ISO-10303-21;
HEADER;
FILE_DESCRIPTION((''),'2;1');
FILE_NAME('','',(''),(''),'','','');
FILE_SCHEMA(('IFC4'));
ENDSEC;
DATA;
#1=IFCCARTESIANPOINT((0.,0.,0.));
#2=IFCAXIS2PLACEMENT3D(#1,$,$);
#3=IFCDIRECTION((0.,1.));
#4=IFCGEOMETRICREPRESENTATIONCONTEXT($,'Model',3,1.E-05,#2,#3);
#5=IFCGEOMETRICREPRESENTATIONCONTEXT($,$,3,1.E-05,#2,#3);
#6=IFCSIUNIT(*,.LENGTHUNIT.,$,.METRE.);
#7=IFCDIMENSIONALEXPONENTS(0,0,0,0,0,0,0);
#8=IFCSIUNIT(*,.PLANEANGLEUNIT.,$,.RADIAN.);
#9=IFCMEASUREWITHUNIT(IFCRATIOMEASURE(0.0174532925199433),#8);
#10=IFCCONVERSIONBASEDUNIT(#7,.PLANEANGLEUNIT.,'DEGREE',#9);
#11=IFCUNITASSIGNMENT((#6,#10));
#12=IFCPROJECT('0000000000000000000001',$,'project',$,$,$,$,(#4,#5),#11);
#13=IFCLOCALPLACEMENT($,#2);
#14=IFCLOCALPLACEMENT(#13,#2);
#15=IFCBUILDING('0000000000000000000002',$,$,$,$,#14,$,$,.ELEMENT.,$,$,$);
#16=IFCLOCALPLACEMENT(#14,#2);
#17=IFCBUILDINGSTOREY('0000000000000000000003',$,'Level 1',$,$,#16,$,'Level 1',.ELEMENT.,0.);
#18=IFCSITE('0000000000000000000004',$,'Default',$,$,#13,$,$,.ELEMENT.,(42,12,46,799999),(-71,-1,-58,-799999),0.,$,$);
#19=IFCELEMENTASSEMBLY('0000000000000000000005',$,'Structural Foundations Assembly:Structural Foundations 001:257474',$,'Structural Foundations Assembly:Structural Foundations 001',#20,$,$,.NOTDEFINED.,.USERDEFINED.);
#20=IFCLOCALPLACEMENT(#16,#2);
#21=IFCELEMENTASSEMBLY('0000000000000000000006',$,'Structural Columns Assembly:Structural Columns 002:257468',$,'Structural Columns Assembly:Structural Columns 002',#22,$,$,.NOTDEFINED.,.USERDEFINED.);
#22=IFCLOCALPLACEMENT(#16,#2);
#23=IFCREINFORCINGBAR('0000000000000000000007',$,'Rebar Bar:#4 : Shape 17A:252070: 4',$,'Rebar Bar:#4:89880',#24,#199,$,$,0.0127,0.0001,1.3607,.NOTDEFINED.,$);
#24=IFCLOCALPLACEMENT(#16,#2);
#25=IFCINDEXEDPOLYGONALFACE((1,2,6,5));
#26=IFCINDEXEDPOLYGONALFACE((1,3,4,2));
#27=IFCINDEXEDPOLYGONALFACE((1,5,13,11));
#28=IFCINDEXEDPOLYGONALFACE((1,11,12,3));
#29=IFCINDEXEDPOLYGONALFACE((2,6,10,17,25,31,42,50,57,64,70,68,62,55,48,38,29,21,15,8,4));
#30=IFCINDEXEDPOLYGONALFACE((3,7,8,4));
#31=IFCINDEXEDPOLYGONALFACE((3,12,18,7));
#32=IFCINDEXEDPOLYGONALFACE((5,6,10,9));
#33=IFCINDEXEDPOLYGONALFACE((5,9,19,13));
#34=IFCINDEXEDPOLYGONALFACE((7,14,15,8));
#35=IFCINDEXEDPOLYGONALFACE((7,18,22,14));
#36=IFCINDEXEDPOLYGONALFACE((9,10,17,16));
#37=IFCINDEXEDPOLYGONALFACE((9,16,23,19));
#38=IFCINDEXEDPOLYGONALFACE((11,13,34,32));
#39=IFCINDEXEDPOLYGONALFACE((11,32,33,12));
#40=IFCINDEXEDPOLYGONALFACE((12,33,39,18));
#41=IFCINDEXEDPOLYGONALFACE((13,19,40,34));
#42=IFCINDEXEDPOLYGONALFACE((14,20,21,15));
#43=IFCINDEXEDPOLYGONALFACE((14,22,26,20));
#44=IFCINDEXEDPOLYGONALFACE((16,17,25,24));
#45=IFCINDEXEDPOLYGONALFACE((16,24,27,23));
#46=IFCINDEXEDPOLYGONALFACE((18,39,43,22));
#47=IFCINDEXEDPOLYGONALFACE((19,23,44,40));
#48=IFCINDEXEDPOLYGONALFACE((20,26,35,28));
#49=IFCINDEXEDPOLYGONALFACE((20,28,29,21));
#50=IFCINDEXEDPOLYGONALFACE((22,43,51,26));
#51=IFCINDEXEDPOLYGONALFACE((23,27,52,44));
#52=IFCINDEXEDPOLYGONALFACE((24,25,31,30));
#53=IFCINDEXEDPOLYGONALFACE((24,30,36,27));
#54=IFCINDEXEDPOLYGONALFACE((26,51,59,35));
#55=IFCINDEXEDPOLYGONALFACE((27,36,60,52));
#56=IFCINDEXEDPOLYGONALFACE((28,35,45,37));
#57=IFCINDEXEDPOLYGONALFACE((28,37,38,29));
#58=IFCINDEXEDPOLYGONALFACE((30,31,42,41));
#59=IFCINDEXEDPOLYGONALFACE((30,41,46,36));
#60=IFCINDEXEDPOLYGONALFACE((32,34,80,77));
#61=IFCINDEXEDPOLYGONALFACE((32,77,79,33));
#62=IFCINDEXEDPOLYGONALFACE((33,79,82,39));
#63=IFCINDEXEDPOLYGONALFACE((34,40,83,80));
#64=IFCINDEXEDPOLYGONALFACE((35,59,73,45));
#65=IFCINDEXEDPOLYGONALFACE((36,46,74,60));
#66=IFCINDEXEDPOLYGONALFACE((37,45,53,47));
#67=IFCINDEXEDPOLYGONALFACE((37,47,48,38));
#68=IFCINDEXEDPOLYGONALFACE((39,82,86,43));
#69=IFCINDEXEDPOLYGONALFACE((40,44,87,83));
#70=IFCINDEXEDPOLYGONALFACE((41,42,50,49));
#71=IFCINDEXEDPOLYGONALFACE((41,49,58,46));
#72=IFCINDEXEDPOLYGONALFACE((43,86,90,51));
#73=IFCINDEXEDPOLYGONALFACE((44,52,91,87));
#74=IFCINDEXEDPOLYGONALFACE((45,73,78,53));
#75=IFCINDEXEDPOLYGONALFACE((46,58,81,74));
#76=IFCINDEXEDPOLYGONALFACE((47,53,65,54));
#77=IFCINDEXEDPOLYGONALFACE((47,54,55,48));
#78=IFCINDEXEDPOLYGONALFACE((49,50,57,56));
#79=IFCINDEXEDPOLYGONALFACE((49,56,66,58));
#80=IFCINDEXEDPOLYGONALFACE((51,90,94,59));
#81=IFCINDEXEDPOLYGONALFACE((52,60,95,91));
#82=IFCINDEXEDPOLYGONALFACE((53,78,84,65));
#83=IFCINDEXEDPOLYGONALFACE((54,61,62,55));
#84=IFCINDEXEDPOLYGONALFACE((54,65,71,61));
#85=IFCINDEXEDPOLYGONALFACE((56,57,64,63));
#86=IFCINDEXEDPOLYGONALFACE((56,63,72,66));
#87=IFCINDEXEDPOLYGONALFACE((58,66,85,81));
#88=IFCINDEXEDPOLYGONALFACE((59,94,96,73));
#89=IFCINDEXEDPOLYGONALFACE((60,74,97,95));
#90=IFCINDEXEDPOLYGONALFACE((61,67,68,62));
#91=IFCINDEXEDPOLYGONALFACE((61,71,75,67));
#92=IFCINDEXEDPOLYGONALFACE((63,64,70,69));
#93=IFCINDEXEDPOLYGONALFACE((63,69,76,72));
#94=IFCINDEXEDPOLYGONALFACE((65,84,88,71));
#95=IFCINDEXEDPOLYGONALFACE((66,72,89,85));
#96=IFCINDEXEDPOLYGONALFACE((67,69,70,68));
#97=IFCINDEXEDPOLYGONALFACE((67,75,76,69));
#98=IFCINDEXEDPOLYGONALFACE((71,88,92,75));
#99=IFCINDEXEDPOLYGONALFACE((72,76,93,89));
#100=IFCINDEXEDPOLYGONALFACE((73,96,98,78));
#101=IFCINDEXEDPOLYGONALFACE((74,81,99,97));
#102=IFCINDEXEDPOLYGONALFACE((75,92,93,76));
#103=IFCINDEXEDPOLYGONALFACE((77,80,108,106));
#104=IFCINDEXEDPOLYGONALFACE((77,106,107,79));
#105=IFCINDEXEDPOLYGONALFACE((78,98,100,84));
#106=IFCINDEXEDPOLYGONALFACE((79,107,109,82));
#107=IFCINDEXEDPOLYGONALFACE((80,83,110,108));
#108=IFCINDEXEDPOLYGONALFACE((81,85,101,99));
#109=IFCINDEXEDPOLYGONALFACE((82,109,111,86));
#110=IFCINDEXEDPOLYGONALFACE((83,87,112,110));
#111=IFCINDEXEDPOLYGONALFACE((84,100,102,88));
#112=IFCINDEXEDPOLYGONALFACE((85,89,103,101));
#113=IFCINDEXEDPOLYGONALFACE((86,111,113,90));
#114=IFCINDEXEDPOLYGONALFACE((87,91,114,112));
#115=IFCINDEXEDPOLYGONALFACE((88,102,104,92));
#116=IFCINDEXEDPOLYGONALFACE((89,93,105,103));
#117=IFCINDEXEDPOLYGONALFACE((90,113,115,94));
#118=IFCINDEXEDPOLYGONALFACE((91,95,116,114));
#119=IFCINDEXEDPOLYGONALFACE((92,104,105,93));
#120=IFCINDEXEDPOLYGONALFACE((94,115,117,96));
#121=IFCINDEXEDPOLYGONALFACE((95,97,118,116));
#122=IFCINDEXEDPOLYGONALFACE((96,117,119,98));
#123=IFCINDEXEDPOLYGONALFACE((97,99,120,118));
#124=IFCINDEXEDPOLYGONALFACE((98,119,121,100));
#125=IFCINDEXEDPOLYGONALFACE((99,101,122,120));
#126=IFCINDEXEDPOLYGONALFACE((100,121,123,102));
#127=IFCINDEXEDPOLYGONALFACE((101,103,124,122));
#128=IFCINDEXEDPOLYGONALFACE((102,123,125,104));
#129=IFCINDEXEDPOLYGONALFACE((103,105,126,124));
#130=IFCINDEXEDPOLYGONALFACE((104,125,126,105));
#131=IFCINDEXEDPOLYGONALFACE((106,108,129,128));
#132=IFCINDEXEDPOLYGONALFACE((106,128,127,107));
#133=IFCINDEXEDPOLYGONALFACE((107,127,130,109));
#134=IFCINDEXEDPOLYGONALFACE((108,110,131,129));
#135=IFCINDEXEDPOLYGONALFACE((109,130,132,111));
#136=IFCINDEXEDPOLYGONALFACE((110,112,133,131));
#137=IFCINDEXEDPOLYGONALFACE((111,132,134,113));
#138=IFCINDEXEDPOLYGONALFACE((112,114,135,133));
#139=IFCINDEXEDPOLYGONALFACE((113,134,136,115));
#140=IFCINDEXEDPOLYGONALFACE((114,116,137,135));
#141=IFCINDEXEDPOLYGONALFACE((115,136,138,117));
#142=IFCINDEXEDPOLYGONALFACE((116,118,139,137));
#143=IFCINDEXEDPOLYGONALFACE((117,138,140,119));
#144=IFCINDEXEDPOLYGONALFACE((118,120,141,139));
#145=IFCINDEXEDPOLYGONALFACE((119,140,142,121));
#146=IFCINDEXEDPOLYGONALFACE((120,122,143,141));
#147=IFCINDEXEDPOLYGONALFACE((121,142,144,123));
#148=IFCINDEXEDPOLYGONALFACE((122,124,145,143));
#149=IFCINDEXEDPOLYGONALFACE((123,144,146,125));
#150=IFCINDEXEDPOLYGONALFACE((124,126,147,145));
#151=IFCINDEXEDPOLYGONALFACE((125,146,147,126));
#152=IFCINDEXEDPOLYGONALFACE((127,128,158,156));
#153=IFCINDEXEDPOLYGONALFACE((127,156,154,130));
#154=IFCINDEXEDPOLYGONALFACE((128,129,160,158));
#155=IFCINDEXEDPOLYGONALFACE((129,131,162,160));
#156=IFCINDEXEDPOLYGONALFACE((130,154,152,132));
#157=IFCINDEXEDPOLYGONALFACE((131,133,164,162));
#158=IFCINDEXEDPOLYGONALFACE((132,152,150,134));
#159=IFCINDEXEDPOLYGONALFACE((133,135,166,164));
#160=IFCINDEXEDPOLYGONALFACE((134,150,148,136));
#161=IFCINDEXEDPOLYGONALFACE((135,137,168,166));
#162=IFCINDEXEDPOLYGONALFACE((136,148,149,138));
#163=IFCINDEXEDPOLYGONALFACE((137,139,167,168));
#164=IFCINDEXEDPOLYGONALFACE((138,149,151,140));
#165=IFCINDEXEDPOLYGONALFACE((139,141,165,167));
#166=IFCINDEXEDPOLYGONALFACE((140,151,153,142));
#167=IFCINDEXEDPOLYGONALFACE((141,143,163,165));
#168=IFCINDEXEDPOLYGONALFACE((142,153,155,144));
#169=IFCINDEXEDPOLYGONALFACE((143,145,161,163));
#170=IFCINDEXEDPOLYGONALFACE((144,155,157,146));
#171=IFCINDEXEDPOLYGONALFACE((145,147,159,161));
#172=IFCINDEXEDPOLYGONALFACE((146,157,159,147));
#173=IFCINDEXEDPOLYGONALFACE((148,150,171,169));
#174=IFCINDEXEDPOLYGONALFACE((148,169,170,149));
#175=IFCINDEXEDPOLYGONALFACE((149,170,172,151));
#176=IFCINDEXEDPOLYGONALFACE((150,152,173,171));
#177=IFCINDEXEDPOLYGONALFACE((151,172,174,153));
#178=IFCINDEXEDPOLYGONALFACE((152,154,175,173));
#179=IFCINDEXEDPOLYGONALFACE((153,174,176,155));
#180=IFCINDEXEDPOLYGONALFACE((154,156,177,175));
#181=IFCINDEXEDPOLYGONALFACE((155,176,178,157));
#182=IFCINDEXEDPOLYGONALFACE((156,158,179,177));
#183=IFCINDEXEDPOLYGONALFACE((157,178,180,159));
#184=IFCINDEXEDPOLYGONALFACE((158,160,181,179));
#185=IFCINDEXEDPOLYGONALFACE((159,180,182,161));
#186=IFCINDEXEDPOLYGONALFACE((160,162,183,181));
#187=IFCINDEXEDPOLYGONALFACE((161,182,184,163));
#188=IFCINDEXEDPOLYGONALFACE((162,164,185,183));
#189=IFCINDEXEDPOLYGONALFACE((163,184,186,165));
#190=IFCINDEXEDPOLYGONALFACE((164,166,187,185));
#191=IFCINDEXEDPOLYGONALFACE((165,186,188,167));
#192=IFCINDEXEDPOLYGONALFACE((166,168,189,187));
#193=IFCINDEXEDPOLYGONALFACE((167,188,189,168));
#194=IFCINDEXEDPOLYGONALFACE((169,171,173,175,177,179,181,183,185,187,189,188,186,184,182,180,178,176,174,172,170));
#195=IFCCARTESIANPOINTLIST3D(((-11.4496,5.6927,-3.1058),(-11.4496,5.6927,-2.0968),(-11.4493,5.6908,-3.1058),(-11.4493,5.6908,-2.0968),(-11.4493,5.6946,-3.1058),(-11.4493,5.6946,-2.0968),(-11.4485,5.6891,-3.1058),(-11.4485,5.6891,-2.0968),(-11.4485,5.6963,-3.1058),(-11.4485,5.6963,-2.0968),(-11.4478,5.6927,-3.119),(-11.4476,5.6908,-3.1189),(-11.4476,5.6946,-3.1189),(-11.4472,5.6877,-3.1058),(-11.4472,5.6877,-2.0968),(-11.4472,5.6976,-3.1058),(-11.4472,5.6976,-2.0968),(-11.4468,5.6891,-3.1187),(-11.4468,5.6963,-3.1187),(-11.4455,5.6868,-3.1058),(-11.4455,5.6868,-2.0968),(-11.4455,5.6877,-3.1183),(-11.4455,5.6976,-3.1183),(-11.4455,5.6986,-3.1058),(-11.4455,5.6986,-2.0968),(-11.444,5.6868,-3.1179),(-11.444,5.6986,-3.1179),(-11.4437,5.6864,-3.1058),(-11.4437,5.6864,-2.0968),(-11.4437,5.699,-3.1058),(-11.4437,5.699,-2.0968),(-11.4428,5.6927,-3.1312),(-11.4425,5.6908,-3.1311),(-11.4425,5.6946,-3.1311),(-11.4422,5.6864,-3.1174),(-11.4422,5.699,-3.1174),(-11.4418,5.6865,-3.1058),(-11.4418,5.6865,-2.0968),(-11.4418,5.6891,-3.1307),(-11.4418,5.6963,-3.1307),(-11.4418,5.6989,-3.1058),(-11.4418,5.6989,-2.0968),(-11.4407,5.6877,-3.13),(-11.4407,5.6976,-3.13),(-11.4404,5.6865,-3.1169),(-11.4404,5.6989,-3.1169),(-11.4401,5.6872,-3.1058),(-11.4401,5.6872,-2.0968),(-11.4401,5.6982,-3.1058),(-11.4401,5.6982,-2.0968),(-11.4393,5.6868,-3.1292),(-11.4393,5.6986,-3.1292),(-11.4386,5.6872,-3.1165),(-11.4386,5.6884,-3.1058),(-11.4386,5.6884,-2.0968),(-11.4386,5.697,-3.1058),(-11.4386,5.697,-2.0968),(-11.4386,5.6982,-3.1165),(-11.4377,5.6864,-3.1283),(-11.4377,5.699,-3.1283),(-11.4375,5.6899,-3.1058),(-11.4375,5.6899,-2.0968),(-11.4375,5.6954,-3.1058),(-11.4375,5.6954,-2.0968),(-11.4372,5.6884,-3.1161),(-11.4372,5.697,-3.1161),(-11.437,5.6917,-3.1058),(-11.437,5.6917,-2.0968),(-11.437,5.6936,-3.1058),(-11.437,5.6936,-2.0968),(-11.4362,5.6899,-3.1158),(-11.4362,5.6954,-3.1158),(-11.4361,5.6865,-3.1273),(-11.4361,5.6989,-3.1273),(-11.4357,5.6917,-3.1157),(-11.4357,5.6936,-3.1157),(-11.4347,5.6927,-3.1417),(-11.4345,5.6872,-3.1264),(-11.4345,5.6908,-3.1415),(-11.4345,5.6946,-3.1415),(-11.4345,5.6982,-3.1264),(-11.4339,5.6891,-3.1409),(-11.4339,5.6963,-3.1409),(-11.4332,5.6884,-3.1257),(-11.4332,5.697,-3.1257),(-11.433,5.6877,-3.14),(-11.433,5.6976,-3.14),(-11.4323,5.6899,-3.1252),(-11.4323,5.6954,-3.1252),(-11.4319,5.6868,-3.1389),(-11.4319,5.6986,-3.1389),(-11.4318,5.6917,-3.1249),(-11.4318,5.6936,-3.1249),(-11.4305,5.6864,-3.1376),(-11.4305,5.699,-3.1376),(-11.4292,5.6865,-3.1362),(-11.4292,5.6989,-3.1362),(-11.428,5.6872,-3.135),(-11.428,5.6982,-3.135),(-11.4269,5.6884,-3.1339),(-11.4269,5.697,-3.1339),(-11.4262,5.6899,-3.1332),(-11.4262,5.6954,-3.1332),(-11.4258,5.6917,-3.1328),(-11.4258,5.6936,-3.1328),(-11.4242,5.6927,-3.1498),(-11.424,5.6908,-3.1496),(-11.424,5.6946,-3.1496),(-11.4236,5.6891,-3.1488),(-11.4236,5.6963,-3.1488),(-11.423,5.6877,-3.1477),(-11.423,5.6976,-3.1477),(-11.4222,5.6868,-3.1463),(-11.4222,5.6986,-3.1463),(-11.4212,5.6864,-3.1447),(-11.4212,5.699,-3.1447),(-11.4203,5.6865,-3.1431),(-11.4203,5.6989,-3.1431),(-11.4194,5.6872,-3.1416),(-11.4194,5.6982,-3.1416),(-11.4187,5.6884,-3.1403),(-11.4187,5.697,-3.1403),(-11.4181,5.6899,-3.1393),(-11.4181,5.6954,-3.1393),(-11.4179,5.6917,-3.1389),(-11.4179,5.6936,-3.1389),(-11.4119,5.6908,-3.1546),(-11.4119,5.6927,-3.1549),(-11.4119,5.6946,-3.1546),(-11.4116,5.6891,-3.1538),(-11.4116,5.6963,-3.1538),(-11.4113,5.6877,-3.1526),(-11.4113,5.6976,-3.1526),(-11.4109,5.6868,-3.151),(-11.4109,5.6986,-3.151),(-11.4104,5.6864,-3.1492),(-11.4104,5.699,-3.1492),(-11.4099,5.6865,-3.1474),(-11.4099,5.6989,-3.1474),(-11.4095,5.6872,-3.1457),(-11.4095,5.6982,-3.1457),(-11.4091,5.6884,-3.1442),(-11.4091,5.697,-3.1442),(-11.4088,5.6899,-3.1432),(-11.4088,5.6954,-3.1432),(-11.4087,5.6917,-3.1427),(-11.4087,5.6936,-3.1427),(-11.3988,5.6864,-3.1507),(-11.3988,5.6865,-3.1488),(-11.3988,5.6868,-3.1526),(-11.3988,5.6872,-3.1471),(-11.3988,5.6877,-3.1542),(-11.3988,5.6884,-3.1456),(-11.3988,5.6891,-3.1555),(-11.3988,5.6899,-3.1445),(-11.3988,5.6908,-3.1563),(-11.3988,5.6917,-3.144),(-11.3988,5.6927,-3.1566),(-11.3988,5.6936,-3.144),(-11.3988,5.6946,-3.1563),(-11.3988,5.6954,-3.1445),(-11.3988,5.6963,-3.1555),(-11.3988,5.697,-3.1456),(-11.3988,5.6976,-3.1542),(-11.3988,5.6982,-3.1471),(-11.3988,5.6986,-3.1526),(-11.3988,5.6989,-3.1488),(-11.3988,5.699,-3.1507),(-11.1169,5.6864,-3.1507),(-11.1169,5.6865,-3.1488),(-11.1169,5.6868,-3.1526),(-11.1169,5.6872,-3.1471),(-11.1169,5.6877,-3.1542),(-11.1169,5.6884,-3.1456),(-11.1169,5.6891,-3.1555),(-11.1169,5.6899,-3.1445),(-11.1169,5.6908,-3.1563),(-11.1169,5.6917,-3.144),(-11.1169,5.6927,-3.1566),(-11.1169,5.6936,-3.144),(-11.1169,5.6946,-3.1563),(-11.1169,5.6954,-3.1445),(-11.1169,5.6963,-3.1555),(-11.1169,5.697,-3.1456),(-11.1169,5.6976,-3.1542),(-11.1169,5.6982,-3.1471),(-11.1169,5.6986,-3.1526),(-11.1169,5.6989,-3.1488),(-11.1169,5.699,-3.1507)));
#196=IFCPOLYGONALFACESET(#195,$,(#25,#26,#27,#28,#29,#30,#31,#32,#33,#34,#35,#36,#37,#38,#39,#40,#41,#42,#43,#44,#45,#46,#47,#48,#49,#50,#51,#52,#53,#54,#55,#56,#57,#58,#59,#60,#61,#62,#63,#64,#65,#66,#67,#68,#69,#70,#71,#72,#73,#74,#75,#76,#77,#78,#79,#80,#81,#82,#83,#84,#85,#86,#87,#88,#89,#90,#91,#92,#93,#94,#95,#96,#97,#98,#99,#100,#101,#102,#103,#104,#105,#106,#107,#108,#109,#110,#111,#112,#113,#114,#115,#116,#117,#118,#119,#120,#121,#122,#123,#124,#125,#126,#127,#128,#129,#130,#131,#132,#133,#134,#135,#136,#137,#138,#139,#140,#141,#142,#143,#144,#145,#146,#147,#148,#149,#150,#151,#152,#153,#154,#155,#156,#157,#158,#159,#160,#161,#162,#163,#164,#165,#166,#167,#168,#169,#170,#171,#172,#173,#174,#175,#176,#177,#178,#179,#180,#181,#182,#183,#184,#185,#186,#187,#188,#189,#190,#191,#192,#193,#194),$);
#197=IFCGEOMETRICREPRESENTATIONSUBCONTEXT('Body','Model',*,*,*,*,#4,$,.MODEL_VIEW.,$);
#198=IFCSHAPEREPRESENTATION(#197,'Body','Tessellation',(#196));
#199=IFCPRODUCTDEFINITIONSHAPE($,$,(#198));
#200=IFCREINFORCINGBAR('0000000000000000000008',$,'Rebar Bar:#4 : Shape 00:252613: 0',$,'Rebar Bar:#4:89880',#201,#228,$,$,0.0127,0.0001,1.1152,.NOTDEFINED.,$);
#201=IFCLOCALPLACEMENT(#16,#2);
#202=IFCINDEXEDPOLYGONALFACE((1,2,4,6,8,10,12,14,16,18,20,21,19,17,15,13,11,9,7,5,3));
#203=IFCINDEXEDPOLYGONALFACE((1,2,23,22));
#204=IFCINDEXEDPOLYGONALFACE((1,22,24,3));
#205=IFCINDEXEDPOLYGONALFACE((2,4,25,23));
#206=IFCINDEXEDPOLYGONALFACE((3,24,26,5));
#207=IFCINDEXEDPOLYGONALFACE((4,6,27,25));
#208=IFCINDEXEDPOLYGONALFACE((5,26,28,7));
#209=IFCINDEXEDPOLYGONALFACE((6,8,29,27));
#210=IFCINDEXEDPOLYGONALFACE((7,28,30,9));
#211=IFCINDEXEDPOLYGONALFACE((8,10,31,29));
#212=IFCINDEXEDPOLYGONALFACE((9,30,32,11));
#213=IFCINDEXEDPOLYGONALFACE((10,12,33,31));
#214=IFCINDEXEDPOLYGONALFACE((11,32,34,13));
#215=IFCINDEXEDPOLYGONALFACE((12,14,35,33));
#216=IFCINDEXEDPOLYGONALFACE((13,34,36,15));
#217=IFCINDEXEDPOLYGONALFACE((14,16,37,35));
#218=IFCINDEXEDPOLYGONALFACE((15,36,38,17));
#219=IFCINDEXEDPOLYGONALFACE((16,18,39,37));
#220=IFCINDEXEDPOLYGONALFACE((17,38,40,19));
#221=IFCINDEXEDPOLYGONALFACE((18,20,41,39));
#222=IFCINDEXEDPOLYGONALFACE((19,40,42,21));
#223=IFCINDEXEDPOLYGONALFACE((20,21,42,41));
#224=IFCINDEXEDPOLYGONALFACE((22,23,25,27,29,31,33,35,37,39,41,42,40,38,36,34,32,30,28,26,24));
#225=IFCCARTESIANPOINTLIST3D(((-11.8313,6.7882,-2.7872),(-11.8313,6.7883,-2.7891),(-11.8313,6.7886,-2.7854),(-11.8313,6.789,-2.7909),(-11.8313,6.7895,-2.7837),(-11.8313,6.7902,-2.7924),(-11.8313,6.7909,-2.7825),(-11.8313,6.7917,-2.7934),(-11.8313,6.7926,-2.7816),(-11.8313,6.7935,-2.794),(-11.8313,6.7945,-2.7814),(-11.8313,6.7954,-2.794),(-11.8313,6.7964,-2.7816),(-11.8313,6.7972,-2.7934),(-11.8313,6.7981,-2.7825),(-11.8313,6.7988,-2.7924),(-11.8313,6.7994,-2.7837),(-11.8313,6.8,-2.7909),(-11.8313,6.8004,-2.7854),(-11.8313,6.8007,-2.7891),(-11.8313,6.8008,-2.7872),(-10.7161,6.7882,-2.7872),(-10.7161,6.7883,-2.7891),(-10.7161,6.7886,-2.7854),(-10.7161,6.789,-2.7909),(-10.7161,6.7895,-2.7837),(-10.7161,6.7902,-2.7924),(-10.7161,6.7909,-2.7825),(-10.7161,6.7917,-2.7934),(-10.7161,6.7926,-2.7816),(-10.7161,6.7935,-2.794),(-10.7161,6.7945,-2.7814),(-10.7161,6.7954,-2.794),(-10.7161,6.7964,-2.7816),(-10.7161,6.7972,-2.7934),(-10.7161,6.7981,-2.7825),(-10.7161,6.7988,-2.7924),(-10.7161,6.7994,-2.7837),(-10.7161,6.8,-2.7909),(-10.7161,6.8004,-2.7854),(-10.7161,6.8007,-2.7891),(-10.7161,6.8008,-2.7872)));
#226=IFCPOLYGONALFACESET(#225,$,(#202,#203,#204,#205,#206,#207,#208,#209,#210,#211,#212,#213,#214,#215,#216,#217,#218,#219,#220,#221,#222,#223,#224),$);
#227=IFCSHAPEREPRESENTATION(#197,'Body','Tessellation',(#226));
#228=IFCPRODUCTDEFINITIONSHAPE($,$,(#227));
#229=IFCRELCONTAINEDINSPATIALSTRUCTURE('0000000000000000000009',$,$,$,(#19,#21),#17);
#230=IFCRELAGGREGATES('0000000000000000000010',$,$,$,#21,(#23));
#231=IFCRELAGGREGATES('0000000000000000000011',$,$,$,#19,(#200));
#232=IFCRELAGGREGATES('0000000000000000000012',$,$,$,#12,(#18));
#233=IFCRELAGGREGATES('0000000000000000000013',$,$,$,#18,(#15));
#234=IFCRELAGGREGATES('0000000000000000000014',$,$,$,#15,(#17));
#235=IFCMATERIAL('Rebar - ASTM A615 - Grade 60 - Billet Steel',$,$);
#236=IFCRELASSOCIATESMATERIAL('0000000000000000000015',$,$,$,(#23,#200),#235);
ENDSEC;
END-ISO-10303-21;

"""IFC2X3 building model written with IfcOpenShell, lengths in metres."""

from ifc_helpers import new_model, entity, si_unit, converted_unit, direction, origin, place, context, subcontext, project, spatial, material, element, aggregate, save


model = new_model("IFC2X3")

# Units and contexts
model_context = context("Model", 3, precision=1e-05, world=origin(), true_north=direction((0.0, 1.0)))
context_of_model = context(None, 3, precision=1e-05, world=origin(), true_north=direction((0.0, 1.0)))
body_context = subcontext(model_context, "Body", "Model", "MODEL_VIEW")
ifc_project = project(units=[si_unit("LENGTHUNIT", "METRE"), converted_unit("PLANEANGLEUNIT", "DEGREE", entity("IfcRatioMeasure", 0.0174532925199433), si_unit("PLANEANGLEUNIT", "RADIAN"), dimensions=[0, 0, 0, 0, 0, 0, 0])], contexts=[model_context, context_of_model])

# Site, building, storey
site_placement = place(None, origin())
site = spatial("IfcSite", under=ifc_project, at=site_placement, Name="Default", CompositionType="ELEMENT", RefLatitude=(42, 12, 46, 799999), RefLongitude=(-71, -1, -58, -799999), RefElevation=0.0)
building_placement = place(site_placement, origin())
building = spatial("IfcBuilding", under=site, at=building_placement, CompositionType="ELEMENT")
storey_placement = place(building_placement, origin())
storey = spatial("IfcBuildingStorey", under=building, at=storey_placement, Name="Level 1", LongName="Level 1", CompositionType="ELEMENT", Elevation=0.0)

# Element assembly
assembly_1_placement = place(storey_placement, origin())
assembly_1 = element("IfcElementAssembly", 1, at=assembly_1_placement, inside=storey, Name="Structural Foundations Assembly:Structural Foundations 001:257474", ObjectType="Structural Foundations Assembly:Structural Foundations 001", AssemblyPlace="NOTDEFINED", PredefinedType="USERDEFINED")

# Element assembly, reinforcing bar
assembly_2_placement = place(storey_placement, origin())
assembly_2 = element("IfcElementAssembly", 2, at=assembly_2_placement, inside=storey, Name="Structural Columns Assembly:Structural Columns 002:257468", ObjectType="Structural Columns Assembly:Structural Columns 002", AssemblyPlace="NOTDEFINED", PredefinedType="USERDEFINED")
ifc_material_1 = material(Name="Rebar - ASTM A615 - Grade 60 - Billet Steel")
reinforcing_bar_1_placement = place(assembly_2_placement, origin())
reinforcing_bar_1 = element("IfcReinforcingBar", 3, at=reinforcing_bar_1_placement, material=ifc_material_1, Name="Rebar Bar:#4 : Shape 17A:252070: 4", ObjectType="Rebar Bar:#4:89880", BarLength=1.3607, BarRole="NOTDEFINED", CrossSectionArea=0.0001, NominalDiameter=0.0127, context=body_context, shape_type="AdvancedSweptSolid", body=[
    entity("IfcSweptDiskSolid", entity("IfcCompositeCurve", [entity("IfcCompositeCurveSegment", "CONTINUOUS", True, entity("IfcPolyline", [entity("IfcCartesianPoint", [-11.4432, 5.6927, -2.0968]), entity("IfcCartesianPoint", [-11.4432, 5.6927, -3.1058])])), entity("IfcCompositeCurveSegment", "CONTINUOUS", True, entity("IfcTrimmedCurve", entity("IfcCircle", entity("IfcAxis2Placement3D", entity("IfcCartesianPoint", [-11.3988, 5.6927, -3.1058]), entity("IfcDirection", [0.0, -1.0, 0.0]), entity("IfcDirection", [0.0, 0.0, -1.0])), 0.0445), [entity("IfcParameterValue", 270.0)], [entity("IfcParameterValue", 360.0)], True, "PARAMETER")), entity("IfcCompositeCurveSegment", "CONTINUOUS", True, entity("IfcPolyline", [entity("IfcCartesianPoint", [-11.3988, 5.6927, -3.1503]), entity("IfcCartesianPoint", [-11.1169, 5.6927, -3.1503])]))], False), 0.0063, None, 0.0, 92.0),
])
aggregate(assembly_2, [reinforcing_bar_1])

# Reinforcing bar
reinforcing_bar_2_placement = place(assembly_1_placement, origin())
reinforcing_bar_2 = element("IfcReinforcingBar", 4, at=reinforcing_bar_2_placement, material=ifc_material_1, Name="Rebar Bar:#4 : Shape 00:252613: 0", ObjectType="Rebar Bar:#4:89880", BarLength=1.1152, BarRole="NOTDEFINED", CrossSectionArea=0.0001, NominalDiameter=0.0127, context=body_context, shape_type="AdvancedSweptSolid", body=[
    entity("IfcSweptDiskSolid", entity("IfcCompositeCurve", [entity("IfcCompositeCurveSegment", "CONTINUOUS", True, entity("IfcPolyline", [entity("IfcCartesianPoint", [-11.8313, 6.7945, -2.7877]), entity("IfcCartesianPoint", [-10.7161, 6.7945, -2.7877])]))], False), 0.0063, None, 0.0, 1.0),
])
aggregate(assembly_1, [reinforcing_bar_2])

save(model, "model.ifc")
